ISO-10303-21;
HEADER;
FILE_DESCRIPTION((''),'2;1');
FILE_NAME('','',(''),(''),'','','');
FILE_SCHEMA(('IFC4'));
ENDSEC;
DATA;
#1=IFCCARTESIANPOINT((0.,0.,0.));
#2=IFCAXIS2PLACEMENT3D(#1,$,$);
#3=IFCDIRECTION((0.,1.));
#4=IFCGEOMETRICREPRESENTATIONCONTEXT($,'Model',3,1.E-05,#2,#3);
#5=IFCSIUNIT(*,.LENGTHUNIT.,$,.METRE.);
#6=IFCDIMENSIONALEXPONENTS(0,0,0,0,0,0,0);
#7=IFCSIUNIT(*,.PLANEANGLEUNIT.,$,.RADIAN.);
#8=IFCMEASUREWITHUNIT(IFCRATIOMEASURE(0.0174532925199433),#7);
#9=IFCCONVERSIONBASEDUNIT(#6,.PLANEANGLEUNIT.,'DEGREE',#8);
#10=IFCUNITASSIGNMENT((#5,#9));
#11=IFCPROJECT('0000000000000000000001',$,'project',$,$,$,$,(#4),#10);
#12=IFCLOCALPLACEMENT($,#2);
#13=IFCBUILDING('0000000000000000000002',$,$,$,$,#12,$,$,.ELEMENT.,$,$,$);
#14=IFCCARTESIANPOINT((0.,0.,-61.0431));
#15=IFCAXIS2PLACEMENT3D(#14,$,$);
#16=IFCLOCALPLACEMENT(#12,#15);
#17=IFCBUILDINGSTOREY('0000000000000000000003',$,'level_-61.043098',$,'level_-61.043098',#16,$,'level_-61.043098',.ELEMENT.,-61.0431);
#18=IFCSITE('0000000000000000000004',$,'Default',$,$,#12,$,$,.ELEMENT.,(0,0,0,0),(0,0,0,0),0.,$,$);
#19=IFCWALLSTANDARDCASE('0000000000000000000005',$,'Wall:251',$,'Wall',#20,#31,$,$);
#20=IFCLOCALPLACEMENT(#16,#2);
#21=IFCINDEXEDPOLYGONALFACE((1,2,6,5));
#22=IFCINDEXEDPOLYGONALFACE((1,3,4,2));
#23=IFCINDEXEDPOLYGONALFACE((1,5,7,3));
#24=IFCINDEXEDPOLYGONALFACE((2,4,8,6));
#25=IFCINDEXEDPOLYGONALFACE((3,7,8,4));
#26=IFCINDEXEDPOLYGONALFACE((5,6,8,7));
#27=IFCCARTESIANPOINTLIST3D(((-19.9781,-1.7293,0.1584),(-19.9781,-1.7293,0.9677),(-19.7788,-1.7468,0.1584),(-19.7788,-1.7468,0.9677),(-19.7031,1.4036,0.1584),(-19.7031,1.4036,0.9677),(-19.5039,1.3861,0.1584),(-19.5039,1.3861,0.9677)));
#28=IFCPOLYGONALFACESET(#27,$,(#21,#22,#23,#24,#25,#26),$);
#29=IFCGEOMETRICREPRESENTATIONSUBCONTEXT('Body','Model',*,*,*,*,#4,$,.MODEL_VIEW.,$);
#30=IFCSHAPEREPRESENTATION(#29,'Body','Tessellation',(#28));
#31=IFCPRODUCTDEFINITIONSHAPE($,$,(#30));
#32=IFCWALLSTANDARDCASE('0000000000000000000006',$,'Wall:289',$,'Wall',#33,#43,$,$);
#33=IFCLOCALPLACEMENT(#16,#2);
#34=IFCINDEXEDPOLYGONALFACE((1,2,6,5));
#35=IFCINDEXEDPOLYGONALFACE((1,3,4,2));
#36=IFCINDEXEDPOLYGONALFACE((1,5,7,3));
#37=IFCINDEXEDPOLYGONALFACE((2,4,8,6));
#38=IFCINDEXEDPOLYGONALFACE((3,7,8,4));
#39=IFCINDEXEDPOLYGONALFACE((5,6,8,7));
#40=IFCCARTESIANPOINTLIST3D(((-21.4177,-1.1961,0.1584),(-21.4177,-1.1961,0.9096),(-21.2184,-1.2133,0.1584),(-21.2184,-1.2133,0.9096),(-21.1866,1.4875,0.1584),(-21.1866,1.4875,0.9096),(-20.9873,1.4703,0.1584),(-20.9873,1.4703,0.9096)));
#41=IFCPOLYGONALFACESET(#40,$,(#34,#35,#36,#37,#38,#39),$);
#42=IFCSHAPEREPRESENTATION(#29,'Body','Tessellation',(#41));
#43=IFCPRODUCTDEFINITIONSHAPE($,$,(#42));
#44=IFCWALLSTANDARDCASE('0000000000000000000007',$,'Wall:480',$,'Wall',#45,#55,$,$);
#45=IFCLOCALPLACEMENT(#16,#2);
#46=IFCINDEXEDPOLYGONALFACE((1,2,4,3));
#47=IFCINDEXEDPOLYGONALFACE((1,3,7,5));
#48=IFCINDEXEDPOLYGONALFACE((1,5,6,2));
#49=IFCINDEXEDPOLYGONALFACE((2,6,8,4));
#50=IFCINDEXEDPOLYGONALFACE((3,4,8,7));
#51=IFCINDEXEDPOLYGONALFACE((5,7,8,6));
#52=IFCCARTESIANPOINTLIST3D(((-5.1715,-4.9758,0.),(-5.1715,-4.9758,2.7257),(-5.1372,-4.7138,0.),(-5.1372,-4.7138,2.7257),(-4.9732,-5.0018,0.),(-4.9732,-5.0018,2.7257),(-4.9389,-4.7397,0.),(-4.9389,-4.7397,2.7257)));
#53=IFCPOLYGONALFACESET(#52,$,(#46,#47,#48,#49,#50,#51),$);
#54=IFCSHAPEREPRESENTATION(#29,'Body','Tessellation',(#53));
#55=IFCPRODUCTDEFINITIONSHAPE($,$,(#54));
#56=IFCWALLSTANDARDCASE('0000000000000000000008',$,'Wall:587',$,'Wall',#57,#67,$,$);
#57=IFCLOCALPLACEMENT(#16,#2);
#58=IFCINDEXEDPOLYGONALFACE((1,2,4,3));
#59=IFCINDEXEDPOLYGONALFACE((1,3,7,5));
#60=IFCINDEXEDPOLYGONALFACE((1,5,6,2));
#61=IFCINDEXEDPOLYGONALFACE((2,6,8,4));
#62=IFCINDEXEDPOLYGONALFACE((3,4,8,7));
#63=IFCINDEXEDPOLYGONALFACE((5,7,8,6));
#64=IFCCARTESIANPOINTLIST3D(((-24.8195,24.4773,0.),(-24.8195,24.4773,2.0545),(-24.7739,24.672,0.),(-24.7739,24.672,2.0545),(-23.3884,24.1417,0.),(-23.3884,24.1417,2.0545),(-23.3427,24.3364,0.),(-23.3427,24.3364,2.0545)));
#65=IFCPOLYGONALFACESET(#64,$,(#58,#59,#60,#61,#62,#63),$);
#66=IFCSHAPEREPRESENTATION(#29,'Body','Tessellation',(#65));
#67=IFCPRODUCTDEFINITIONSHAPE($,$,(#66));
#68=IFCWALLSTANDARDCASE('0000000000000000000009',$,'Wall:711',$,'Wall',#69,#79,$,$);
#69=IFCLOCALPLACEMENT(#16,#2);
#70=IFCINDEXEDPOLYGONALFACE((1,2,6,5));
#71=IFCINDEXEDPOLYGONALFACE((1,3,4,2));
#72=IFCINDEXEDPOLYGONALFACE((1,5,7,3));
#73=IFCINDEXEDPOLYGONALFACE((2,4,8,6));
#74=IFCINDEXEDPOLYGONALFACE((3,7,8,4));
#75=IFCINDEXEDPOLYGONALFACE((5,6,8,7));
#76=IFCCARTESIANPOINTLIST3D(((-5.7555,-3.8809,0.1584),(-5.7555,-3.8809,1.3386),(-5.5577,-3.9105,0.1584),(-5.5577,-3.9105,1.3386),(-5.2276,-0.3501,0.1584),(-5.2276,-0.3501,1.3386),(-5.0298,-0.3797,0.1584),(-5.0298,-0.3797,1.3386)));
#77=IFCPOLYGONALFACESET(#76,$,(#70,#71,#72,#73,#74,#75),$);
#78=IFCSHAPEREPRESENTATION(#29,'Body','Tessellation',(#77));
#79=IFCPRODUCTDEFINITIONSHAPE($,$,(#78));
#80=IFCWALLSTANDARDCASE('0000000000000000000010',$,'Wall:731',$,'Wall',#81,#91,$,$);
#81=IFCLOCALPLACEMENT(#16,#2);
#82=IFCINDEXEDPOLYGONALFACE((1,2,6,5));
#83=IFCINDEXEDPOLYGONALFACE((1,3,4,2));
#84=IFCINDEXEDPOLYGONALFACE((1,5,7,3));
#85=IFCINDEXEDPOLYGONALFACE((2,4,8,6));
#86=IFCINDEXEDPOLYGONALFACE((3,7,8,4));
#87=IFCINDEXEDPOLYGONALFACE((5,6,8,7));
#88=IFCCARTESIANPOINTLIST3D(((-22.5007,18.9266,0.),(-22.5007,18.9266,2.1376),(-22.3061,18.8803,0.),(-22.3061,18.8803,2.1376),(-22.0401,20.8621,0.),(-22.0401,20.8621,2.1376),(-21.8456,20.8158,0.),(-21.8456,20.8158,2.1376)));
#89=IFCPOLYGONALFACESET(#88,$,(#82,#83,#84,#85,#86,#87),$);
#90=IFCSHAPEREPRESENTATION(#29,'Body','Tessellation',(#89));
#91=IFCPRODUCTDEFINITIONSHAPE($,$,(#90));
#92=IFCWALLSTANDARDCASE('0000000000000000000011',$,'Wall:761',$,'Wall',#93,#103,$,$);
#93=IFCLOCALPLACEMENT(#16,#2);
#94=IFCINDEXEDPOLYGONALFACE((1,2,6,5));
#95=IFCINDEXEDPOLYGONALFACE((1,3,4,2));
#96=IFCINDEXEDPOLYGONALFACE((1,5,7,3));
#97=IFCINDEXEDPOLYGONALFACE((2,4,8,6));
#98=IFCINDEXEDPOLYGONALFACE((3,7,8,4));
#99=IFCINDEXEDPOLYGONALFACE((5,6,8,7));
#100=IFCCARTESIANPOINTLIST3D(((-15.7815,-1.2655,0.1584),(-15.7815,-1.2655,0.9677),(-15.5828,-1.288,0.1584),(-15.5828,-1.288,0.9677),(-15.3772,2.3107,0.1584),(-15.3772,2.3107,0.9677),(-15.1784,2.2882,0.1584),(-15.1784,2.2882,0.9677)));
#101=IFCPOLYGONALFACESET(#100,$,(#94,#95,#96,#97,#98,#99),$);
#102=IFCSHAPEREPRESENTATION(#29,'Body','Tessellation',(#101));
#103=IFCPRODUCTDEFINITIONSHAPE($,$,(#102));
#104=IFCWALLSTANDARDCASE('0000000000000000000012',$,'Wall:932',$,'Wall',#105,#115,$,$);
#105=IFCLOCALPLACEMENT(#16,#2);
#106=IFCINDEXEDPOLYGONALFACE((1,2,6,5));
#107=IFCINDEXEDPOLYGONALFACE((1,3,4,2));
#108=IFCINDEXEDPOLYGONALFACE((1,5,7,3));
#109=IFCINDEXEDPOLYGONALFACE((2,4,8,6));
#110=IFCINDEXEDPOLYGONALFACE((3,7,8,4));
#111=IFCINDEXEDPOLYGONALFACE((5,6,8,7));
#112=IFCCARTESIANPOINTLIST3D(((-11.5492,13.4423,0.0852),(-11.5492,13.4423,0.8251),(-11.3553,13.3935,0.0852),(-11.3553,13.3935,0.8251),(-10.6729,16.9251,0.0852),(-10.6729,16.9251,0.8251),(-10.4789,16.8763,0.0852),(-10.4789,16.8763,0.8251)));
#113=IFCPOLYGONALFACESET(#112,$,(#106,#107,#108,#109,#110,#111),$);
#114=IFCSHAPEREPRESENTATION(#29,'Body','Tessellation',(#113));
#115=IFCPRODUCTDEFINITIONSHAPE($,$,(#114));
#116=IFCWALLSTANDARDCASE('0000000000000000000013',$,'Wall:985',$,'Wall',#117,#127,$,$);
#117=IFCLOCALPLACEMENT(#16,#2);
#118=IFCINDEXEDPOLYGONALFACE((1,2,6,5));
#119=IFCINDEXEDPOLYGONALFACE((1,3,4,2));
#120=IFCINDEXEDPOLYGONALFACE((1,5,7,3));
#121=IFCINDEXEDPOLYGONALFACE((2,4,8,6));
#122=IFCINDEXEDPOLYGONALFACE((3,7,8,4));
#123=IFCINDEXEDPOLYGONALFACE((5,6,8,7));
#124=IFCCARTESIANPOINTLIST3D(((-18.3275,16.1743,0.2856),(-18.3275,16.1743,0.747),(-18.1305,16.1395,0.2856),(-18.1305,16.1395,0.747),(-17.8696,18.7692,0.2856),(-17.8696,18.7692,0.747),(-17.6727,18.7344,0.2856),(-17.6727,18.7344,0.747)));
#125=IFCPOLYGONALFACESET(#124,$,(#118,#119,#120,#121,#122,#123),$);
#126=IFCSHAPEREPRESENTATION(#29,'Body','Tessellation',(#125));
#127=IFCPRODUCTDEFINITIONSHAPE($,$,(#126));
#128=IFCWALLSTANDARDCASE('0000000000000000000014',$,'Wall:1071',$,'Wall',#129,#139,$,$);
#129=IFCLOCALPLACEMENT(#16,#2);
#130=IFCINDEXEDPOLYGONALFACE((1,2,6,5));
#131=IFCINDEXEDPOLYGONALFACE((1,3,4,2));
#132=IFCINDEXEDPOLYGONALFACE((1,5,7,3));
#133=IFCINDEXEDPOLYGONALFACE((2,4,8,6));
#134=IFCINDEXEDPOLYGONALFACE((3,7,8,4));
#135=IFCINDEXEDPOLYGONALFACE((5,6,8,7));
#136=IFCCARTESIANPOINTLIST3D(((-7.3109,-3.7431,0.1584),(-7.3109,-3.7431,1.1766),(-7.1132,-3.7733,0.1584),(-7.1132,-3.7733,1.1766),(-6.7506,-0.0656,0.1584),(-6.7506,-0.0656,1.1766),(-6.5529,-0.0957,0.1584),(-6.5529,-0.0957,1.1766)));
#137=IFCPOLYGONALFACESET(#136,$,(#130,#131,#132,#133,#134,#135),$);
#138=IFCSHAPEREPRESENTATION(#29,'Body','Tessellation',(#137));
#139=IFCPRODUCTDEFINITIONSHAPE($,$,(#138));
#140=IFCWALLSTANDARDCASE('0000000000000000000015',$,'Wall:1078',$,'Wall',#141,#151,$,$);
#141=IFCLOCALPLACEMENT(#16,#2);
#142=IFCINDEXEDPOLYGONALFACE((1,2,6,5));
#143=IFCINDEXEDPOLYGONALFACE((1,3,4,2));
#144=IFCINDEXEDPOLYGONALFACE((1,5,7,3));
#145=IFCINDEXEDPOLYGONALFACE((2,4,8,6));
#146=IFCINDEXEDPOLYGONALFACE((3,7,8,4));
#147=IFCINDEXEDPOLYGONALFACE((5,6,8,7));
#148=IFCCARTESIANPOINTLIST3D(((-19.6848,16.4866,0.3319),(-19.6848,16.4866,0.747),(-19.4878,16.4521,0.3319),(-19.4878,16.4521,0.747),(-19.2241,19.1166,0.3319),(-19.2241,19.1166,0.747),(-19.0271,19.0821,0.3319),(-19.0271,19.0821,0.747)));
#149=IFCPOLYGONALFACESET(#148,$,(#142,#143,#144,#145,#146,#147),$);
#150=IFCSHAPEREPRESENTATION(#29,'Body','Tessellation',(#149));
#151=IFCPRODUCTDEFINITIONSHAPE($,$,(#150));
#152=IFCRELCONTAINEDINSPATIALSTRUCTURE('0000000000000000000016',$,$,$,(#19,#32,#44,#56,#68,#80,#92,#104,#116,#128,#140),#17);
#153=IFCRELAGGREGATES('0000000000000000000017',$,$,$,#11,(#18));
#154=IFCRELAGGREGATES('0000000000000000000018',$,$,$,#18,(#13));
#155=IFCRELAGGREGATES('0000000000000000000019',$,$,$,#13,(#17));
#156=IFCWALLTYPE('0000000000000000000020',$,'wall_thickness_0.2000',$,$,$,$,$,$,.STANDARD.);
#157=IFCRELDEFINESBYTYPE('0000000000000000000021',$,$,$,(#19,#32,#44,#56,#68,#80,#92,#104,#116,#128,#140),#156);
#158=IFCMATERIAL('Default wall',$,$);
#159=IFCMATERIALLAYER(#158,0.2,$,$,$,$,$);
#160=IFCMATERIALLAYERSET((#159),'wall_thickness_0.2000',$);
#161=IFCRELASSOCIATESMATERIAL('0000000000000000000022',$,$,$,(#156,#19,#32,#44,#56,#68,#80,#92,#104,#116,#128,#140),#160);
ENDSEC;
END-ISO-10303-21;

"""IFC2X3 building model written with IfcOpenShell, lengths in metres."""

from ifc_helpers import new_model, entity, si_unit, converted_unit, direction, frame, origin, place, context, subcontext, project, spatial, polyline, outline, extrude, material, layer, layer_set, layer_usage, type_object, element, save


model = new_model("IFC2X3")

# Units and contexts
model_context = context("Model", 3, precision=1e-05, world=origin(), true_north=direction((0.0, 1.0)))
body_context = subcontext(model_context, "Body", "Model", "MODEL_VIEW")
ifc_project = project(units=[si_unit("LENGTHUNIT", "METRE"), converted_unit("PLANEANGLEUNIT", "DEGREE", entity("IfcRatioMeasure", 0.0174532925199433), si_unit("PLANEANGLEUNIT", "RADIAN"), dimensions=[0, 0, 0, 0, 0, 0, 0])], contexts=[model_context])

# Site, building, storey
placement_1 = place(None, origin())
site = spatial("IfcSite", under=ifc_project, at=placement_1, Name="Default", CompositionType="ELEMENT", RefLatitude=(0, 0, 0, 0), RefLongitude=(0, 0, 0, 0), RefElevation=0.0)
building = spatial("IfcBuilding", under=site, at=placement_1, CompositionType="ELEMENT")
storey_placement = place(placement_1, frame((0.0, 0.0, -61.0431)))
storey = spatial("IfcBuildingStorey", under=building, at=storey_placement, Name="level_-61.043098", ObjectType="level_-61.043098", LongName="level_-61.043098", CompositionType="ELEMENT", Elevation=-61.0431)

# Walls
ifc_material_1 = material(Name="Default wall")
ifc_layer = layer(ifc_material_1, 0.2)
ifc_layer_set = layer_set([ifc_layer], Name="wall_thickness_0.2000")
ifc_layer_usage = layer_usage(ifc_layer_set, "AXIS2", "POSITIVE", -0.1)
wall_type = type_object("IfcWallType", Name="wall_thickness_0.2000", PredefinedType="STANDARD", material=ifc_layer_set)
placement_2 = place(placement_1, frame((0.0, 0.0, -60.8847)))
wall_1_placement = place(placement_2, frame((-19.8785, -1.7381, 0.0), z_axis=(0.0, 0.0, 1.0), x_axis=(0.087435, 0.99617, 0.0)))
element("IfcWallStandardCase", 1, at=wall_1_placement, inside=storey, type_object=wall_type, material=ifc_layer_usage, Name="Wall:251", ObjectType="Wall", context=body_context, shape_type="SweptSolid", body=[
    extrude(outline(polyline([(3.145, -0.1), (3.145, 0.1), (0.0, 0.1), (0.0, -0.1), (3.145, -0.1)])), origin(), (0.0, 0.0, 1.0), 0.8093),
])
placement_3 = place(placement_1, frame((0.0, 0.0, -60.8847)))
wall_2_placement = place(placement_3, frame((-21.318, -1.2047, 0.0), z_axis=(0.0, 0.0, 1.0), x_axis=(0.085799, 0.996312, 0.0)))
element("IfcWallStandardCase", 2, at=wall_2_placement, inside=storey, type_object=wall_type, material=ifc_layer_usage, Name="Wall:289", ObjectType="Wall", context=body_context, shape_type="SweptSolid", body=[
    extrude(outline(polyline([(2.6936, -0.1), (2.6936, 0.1), (0.0, 0.1), (0.0, -0.1), (2.6936, -0.1)])), origin(), (0.0, 0.0, 1.0), 0.7512),
])
wall_3_placement = place(storey_placement, frame((-5.0381, -4.7267, 0.0), z_axis=(0.0, 0.0, 1.0), x_axis=(-0.129665, -0.991558, 0.0)))
element("IfcWallStandardCase", 3, at=wall_3_placement, inside=storey, type_object=wall_type, material=ifc_layer_usage, Name="Wall:480", ObjectType="Wall", context=body_context, shape_type="SweptSolid", body=[
    extrude(outline(polyline([(0.2643, -0.1), (0.2643, 0.1), (0.0, 0.1), (0.0, -0.1), (0.2643, -0.1)])), origin(), (0.0, 0.0, 1.0), 2.7257),
])
wall_4_placement = place(storey_placement, frame((-23.3655, 24.2391, 0.0), z_axis=(0.0, 0.0, 1.0), x_axis=(-0.973601, 0.228258, 0.0)))
element("IfcWallStandardCase", 4, at=wall_4_placement, inside=storey, type_object=wall_type, material=ifc_layer_usage, Name="Wall:587", ObjectType="Wall", context=body_context, shape_type="SweptSolid", body=[
    extrude(outline(polyline([(1.47, -0.1), (1.47, 0.1), (0.0, 0.1), (0.0, -0.1), (1.47, -0.1)])), origin(), (0.0, 0.0, 1.0), 2.0545),
])
placement_4 = place(placement_1, frame((0.0, 0.0, -60.8847)))
wall_5_placement = place(placement_4, frame((-5.6566, -3.8957, 0.0), z_axis=(0.0, 0.0, 1.0), x_axis=(0.147888, 0.989004, 0.0)))
element("IfcWallStandardCase", 5, at=wall_5_placement, inside=storey, type_object=wall_type, material=ifc_layer_usage, Name="Wall:711", ObjectType="Wall", context=body_context, shape_type="SweptSolid", body=[
    extrude(outline(polyline([(3.57, -0.1), (3.57, 0.1), (0.0, 0.1), (0.0, -0.1), (3.57, -0.1)])), origin(), (0.0, 0.0, 1.0), 1.1802),
])
wall_6_placement = place(storey_placement, frame((-21.9428, 20.839, 0.0), z_axis=(0.0, 0.0, 1.0), x_axis=(-0.231495, -0.972836, 0.0)))
element("IfcWallStandardCase", 6, at=wall_6_placement, inside=storey, type_object=wall_type, material=ifc_layer_usage, Name="Wall:731", ObjectType="Wall", context=body_context, shape_type="SweptSolid", body=[
    extrude(outline(polyline([(1.9896, -0.1), (1.9896, 0.1), (0.0, 0.1), (0.0, -0.1), (1.9896, -0.1)])), origin(), (0.0, 0.0, 1.0), 2.1376),
])
placement_5 = place(placement_1, frame((0.0, 0.0, -60.8847)))
wall_7_placement = place(placement_5, frame((-15.6821, -1.2767, 0.0), z_axis=(0.0, 0.0, 1.0), x_axis=(0.112339, 0.99367, 0.0)))
element("IfcWallStandardCase", 7, at=wall_7_placement, inside=storey, type_object=wall_type, material=ifc_layer_usage, Name="Wall:761", ObjectType="Wall", context=body_context, shape_type="SweptSolid", body=[
    extrude(outline(polyline([(3.599, -0.1), (3.599, 0.1), (0.0, 0.1), (0.0, -0.1), (3.599, -0.1)])), origin(), (0.0, 0.0, 1.0), 0.8093),
])
placement_6 = place(placement_1, frame((0.0, 0.0, -60.9579)))
wall_8_placement = place(placement_6, frame((-11.4522, 13.4179, 0.0), z_axis=(0.0, 0.0, 1.0), x_axis=(0.244021, 0.96977, 0.0)))
element("IfcWallStandardCase", 8, at=wall_8_placement, inside=storey, type_object=wall_type, material=ifc_layer_usage, Name="Wall:932", ObjectType="Wall", context=body_context, shape_type="SweptSolid", body=[
    extrude(outline(polyline([(3.5913, -0.1), (3.5913, 0.1), (0.0, 0.1), (0.0, -0.1), (3.5913, -0.1)])), origin(), (0.0, 0.0, 1.0), 0.7399),
])
placement_7 = place(placement_1, frame((0.0, 0.0, -60.7575)))
wall_9_placement = place(placement_7, frame((-18.229, 16.1569, 0.0), z_axis=(0.0, 0.0, 1.0), x_axis=(0.173746, 0.98479, 0.0)))
element("IfcWallStandardCase", 9, at=wall_9_placement, inside=storey, type_object=wall_type, material=ifc_layer_usage, Name="Wall:985", ObjectType="Wall", context=body_context, shape_type="SweptSolid", body=[
    extrude(outline(polyline([(2.635, -0.1), (2.635, 0.1), (0.0, 0.1), (0.0, -0.1), (2.635, -0.1)])), origin(), (0.0, 0.0, 1.0), 0.4614),
])
placement_8 = place(placement_1, frame((0.0, 0.0, -60.8847)))
wall_10_placement = place(placement_8, frame((-7.2121, -3.7582, 0.0), z_axis=(0.0, 0.0, 1.0), x_axis=(0.150626, 0.988591, 0.0)))
element("IfcWallStandardCase", 10, at=wall_10_placement, inside=storey, type_object=wall_type, material=ifc_layer_usage, Name="Wall:1071", ObjectType="Wall", context=body_context, shape_type="SweptSolid", body=[
    extrude(outline(polyline([(3.72, -0.1), (3.72, 0.1), (0.0, 0.1), (0.0, -0.1), (3.72, -0.1)])), origin(), (0.0, 0.0, 1.0), 1.0182),
])
placement_9 = place(placement_1, frame((0.0, 0.0, -60.7112)))
wall_11_placement = place(placement_9, frame((-19.5863, 16.4694, 0.0), z_axis=(0.0, 0.0, 1.0), x_axis=(0.172566, 0.984998, 0.0)))
element("IfcWallStandardCase", 11, at=wall_11_placement, inside=storey, type_object=wall_type, material=ifc_layer_usage, Name="Wall:1078", ObjectType="Wall", context=body_context, shape_type="SweptSolid", body=[
    extrude(outline(polyline([(2.67, -0.1), (2.67, 0.1), (0.0, 0.1), (0.0, -0.1), (2.67, -0.1)])), origin(), (0.0, 0.0, 1.0), 0.4151),
])

save(model, "model.ifc")
